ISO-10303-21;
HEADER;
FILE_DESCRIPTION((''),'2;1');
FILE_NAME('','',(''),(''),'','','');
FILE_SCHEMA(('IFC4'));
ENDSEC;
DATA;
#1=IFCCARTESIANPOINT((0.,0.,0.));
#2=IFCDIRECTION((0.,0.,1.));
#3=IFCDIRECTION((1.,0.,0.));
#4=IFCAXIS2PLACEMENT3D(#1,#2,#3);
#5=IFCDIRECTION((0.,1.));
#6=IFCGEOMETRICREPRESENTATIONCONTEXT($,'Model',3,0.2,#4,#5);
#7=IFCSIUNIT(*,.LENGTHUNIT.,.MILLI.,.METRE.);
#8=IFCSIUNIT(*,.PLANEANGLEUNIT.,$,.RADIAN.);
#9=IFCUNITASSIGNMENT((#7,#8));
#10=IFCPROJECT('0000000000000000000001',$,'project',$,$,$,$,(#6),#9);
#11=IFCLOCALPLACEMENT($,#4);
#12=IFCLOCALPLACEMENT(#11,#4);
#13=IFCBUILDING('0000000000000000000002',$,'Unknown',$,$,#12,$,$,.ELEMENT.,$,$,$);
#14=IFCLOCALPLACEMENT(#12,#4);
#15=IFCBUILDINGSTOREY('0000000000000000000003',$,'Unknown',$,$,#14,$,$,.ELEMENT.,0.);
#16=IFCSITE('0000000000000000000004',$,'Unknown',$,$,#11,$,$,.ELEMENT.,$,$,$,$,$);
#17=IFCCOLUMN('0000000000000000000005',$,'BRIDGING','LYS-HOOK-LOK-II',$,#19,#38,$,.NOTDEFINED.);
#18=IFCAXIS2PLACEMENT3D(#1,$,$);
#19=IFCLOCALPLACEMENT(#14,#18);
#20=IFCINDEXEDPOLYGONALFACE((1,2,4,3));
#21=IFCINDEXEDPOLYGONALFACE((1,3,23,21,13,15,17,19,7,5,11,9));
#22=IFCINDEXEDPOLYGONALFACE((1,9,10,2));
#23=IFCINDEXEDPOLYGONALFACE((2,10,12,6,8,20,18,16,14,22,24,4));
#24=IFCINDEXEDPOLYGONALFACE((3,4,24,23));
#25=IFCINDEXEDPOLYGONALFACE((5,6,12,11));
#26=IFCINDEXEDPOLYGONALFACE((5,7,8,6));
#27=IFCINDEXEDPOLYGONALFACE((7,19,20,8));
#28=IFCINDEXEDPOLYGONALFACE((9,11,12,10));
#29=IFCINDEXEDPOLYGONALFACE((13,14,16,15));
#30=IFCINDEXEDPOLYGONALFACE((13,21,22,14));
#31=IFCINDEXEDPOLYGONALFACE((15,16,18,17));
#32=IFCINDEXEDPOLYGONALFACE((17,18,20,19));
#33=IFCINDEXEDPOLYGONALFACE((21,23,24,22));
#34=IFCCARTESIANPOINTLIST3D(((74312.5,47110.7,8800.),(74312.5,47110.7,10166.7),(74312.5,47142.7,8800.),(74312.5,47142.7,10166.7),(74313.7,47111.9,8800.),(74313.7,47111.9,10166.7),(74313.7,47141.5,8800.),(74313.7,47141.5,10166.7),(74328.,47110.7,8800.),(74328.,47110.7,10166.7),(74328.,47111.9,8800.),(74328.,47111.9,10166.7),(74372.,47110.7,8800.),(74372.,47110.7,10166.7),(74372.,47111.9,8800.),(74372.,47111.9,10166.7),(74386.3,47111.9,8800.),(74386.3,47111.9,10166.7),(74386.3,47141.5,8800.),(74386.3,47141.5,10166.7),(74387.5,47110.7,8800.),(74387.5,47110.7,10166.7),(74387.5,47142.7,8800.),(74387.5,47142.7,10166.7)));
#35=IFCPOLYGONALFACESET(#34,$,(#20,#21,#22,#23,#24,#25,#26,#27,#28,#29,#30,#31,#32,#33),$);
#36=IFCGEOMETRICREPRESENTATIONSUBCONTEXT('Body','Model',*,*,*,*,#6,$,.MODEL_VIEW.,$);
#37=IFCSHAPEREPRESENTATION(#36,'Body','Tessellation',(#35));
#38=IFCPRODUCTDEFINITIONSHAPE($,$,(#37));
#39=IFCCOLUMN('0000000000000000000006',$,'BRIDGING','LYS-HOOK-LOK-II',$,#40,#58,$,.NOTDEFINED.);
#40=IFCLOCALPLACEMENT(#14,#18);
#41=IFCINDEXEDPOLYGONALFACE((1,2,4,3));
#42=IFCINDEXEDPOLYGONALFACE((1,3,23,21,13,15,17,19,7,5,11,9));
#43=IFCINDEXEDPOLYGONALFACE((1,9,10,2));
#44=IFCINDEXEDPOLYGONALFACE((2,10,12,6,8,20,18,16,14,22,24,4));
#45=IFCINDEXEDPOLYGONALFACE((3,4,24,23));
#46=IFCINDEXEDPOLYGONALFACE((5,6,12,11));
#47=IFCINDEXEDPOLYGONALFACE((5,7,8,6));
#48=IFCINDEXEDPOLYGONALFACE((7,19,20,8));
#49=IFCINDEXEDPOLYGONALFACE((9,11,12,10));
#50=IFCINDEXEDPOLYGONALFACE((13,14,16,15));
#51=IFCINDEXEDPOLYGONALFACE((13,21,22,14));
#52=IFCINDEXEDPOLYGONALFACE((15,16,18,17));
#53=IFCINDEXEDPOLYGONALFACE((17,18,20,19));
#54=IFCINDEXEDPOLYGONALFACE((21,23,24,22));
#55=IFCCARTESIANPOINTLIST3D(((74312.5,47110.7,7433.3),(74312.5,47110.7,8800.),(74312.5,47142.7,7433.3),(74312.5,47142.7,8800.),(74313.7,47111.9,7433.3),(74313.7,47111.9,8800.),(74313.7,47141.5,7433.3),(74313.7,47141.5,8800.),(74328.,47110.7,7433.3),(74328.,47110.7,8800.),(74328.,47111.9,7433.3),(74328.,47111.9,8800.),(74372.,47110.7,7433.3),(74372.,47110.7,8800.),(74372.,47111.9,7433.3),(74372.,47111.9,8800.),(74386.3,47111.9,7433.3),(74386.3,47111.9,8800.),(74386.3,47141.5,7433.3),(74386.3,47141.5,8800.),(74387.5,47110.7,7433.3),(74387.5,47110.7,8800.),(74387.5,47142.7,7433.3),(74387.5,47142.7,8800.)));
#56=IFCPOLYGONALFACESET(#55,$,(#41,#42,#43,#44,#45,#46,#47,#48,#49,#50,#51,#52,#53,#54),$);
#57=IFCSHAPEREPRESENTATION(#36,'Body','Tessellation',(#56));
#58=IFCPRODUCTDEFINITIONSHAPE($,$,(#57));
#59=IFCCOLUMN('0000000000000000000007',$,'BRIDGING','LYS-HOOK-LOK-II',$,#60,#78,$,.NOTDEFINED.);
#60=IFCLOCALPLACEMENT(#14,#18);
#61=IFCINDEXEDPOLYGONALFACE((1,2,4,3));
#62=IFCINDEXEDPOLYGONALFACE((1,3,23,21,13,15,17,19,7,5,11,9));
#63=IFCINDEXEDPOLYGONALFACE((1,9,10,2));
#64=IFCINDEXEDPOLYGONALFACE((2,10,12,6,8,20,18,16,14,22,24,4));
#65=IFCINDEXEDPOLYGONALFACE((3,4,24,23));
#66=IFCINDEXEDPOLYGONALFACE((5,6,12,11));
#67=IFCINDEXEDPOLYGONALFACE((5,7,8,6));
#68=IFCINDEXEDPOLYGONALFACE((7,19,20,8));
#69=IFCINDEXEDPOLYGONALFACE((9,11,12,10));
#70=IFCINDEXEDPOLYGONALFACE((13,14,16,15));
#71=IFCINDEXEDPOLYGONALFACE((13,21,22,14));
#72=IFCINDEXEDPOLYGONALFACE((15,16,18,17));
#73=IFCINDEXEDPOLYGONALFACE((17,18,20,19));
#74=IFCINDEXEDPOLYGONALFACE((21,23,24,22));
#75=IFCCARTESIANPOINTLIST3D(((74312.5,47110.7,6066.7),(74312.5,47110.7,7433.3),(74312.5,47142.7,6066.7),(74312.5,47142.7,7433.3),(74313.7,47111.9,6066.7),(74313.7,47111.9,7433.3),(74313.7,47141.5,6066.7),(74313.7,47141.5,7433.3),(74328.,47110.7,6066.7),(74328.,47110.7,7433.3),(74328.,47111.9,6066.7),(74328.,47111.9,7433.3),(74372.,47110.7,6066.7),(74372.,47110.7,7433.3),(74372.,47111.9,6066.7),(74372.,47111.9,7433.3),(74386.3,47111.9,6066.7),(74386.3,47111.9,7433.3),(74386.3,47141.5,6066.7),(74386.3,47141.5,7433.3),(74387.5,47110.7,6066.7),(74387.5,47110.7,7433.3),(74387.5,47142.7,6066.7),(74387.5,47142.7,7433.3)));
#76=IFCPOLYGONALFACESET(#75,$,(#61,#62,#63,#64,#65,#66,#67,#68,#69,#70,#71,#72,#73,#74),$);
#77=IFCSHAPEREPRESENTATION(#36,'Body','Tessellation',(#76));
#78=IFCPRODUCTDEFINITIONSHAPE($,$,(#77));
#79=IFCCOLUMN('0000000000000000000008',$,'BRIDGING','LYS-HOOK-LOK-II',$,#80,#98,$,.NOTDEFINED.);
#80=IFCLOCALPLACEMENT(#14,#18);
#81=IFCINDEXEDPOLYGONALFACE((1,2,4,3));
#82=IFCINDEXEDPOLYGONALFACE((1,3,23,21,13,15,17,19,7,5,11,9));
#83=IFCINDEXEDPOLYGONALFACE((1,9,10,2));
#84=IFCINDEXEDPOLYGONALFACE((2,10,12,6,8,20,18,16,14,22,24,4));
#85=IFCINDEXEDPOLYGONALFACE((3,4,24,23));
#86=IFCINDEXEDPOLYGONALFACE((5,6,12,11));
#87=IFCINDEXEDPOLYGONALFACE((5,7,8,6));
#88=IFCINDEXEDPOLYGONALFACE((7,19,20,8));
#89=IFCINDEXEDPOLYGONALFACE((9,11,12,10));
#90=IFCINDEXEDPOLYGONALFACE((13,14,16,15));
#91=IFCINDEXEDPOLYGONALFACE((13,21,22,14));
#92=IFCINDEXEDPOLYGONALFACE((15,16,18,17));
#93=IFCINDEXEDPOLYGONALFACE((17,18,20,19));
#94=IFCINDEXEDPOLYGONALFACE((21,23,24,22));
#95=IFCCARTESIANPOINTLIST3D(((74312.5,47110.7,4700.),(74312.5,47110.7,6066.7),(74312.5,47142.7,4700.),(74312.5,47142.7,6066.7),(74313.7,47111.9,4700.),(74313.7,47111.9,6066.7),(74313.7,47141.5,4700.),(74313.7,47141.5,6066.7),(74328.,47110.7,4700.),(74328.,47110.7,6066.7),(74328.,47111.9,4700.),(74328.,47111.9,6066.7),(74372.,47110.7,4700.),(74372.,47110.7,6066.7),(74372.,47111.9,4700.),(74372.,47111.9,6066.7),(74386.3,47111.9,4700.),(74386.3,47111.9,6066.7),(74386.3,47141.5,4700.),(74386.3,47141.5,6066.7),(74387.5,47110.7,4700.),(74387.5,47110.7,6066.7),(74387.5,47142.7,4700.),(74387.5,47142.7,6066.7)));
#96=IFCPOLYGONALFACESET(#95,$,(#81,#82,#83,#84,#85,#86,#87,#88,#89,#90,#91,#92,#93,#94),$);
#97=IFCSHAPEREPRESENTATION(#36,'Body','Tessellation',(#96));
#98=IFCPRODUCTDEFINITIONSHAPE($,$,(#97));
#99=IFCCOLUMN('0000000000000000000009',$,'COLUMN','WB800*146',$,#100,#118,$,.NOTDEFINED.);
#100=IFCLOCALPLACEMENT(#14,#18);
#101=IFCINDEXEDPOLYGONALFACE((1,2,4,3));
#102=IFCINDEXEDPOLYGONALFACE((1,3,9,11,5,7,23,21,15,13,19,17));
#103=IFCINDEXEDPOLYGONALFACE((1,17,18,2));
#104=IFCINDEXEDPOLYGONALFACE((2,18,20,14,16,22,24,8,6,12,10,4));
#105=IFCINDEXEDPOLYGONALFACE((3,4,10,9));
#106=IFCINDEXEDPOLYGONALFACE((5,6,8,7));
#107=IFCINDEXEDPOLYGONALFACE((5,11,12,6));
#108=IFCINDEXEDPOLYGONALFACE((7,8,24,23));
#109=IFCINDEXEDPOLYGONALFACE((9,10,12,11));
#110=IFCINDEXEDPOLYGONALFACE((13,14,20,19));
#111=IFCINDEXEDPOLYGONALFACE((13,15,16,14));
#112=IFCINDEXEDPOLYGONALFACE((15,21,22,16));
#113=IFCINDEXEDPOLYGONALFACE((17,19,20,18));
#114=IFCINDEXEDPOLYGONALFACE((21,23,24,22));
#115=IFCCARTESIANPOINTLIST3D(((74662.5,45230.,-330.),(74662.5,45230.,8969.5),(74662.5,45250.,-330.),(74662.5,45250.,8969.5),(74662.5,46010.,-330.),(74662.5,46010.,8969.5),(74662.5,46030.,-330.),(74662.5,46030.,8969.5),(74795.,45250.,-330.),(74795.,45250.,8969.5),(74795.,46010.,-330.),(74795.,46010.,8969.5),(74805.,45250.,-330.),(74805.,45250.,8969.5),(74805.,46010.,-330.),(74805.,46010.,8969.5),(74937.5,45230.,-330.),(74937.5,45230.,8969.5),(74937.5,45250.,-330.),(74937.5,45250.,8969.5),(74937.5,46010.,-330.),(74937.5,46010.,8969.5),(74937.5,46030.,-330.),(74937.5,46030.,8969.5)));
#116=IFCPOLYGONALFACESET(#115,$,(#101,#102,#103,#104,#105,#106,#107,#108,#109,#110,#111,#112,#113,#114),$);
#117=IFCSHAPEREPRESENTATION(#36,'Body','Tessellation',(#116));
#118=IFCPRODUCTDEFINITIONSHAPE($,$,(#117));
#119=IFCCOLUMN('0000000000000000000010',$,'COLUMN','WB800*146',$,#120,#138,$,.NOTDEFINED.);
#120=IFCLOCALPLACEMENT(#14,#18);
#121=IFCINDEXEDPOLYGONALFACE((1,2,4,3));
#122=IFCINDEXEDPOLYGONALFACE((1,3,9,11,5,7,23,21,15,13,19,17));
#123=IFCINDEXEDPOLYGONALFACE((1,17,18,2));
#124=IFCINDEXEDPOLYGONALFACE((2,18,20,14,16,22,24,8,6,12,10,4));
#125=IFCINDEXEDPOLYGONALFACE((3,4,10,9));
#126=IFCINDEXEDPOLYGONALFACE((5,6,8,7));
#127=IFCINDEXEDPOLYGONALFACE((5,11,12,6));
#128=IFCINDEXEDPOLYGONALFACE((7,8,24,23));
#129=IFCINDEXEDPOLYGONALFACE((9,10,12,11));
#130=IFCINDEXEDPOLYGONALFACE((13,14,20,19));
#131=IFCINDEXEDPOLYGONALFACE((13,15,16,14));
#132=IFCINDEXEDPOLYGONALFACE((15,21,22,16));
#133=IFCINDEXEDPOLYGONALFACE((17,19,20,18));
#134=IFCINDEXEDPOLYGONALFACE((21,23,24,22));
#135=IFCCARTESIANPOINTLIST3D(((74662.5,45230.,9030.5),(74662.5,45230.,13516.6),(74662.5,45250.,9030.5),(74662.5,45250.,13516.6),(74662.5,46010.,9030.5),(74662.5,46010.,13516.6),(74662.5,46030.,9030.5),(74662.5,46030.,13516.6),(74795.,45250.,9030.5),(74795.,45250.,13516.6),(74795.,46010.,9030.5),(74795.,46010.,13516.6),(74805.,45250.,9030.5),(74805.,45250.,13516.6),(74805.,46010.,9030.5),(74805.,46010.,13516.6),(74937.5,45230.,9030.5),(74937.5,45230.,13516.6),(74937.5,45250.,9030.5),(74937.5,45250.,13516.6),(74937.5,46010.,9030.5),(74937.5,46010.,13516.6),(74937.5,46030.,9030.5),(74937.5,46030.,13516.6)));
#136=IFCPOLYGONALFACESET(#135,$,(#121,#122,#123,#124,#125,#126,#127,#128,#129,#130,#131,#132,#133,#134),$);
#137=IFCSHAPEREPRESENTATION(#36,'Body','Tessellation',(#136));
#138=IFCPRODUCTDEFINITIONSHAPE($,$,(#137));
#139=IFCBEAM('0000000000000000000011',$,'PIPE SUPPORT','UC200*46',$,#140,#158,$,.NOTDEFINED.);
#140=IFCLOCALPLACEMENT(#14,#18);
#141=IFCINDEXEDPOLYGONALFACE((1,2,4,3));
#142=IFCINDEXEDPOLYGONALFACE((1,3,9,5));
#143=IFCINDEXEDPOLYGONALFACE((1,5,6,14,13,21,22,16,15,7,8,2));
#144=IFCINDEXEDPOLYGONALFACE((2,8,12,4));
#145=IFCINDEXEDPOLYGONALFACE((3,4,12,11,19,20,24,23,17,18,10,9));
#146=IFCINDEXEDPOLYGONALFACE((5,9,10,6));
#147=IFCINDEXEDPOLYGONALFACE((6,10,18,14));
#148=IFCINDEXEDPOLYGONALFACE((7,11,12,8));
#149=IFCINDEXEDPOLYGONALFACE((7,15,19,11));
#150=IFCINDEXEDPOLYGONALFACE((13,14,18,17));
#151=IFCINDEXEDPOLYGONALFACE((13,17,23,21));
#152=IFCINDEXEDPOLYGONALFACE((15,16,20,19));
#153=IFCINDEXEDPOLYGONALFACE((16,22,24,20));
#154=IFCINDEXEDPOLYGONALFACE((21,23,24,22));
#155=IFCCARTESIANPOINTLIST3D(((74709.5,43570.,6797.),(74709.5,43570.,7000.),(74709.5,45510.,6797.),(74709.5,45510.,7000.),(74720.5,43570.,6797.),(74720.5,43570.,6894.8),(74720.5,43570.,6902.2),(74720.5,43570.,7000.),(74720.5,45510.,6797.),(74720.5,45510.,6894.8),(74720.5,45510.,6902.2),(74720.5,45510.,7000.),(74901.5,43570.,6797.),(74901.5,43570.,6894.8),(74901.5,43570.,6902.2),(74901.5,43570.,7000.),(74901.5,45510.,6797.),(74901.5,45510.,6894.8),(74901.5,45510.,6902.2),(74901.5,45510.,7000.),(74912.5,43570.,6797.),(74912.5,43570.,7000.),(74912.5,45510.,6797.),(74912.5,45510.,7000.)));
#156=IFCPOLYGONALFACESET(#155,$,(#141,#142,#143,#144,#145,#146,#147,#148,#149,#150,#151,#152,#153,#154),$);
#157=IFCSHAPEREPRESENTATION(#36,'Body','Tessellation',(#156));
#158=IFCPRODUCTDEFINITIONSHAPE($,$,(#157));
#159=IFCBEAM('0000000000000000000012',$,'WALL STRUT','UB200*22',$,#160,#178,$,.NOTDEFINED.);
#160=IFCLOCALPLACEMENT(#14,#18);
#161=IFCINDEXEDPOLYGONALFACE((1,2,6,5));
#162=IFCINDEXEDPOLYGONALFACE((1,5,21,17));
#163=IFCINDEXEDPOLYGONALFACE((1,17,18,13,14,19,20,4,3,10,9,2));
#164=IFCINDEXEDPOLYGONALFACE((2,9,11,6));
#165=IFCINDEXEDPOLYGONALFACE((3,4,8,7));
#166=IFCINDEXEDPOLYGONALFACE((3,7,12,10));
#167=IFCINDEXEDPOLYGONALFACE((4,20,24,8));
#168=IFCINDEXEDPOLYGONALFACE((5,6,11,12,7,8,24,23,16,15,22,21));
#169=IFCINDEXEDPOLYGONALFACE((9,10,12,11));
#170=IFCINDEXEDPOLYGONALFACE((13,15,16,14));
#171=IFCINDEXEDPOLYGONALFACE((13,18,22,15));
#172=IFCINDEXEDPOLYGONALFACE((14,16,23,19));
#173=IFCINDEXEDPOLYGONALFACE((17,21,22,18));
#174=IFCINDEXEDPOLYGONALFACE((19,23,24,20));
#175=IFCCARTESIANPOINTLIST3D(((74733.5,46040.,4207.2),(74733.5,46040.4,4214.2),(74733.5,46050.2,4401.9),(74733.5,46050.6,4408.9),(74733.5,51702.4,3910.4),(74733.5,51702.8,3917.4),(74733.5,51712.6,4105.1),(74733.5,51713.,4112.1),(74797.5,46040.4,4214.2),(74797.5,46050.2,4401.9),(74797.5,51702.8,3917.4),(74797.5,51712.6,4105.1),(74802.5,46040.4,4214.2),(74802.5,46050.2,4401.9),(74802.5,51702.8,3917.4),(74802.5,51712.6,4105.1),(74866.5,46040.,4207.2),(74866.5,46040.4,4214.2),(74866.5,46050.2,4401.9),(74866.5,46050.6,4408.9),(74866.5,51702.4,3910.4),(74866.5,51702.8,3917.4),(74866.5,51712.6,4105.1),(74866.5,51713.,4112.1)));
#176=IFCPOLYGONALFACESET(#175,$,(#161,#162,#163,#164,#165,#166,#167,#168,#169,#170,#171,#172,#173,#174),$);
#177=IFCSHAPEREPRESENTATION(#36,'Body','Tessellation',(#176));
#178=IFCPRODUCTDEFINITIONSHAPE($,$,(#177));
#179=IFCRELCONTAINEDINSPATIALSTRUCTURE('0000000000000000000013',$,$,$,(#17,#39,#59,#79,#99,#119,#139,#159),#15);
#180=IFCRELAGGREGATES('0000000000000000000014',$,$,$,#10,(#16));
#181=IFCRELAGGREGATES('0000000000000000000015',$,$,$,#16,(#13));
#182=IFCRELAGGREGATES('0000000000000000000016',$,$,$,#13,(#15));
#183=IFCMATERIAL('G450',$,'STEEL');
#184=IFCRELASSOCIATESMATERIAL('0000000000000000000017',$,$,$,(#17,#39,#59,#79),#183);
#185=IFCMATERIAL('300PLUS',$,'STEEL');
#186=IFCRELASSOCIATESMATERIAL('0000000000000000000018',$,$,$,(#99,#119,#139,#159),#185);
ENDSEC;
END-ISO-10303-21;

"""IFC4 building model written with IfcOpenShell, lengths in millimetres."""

from ifc_helpers import new_model, si_unit, direction, frame, origin_with_axes, place, context, subcontext, project, spatial, line, indexed_curve, outline, extrude, material, element, save


model = new_model("IFC4")

# Units and contexts
model_context = context("Model", 3, precision=0.2, world=origin_with_axes(), true_north=direction((0.0, 1.0)))
body_context = subcontext(model_context, "Body", "Model", "MODEL_VIEW")
ifc_project = project(units=[si_unit("LENGTHUNIT", "METRE", prefix="MILLI"), si_unit("PLANEANGLEUNIT", "RADIAN")], contexts=[model_context])

# Site, building, storey
site_placement = place(None, origin_with_axes())
site = spatial("IfcSite", under=ifc_project, at=site_placement, Name="Unknown", CompositionType="ELEMENT")
building_placement = place(site_placement, origin_with_axes())
building = spatial("IfcBuilding", under=site, at=building_placement, Name="Unknown", CompositionType="ELEMENT")
storey_placement = place(building_placement, origin_with_axes())
storey = spatial("IfcBuildingStorey", under=building, at=storey_placement, Name="Unknown", CompositionType="ELEMENT", Elevation=0.0)

# Columns
ifc_material_1 = material(Name="G450", Category="STEEL")
for number, where, z_axis, x_axis, name in (
    (1, (74350.0, 47126.7, 8800.0), (0.0, -1.0, 0.0), (0.0, 0.0, 1.0), "BRIDGING"),
    (2, (74350.0, 47126.7, 7433.3), (0.0, -1.0, 0.0), (0.0, 0.0, 1.0), "BRIDGING"),
):
    element("IfcColumn", number, at=place(storey_placement, frame(where, z_axis=z_axis, x_axis=x_axis)), inside=storey, material=ifc_material_1, Name=name, Description="LYS-HOOK-LOK-II", PredefinedType="NOTDEFINED", context=body_context, shape_type="SolidModel", body=[
        extrude(outline(indexed_curve([(16.0, -37.5), (16.0, -22.0), (14.8, -22.0), (14.8, -36.3), (-14.8, -36.3), (-14.8, 36.3), (14.8, 36.3), (14.8, 22.0), (16.0, 22.0), (16.0, 37.5), (-16.0, 37.5), (-16.0, -37.5)], segments=[line(1, 2, 3, 4, 5, 6, 7, 8, 9, 10, 11, 12, 1)])), frame((0.0, 0.0, 0.0), z_axis=(-1.0, 0.0, 0.0), x_axis=(0.0, 0.0, 1.0)), (0.0, 0.0, -1.0), 1366.7),
    ])
column_1_placement = place(storey_placement, frame((74350.0, 47126.7, 6066.7), z_axis=(0.0, -1.0, 0.0), x_axis=(0.0, 0.0, 1.0)))
element("IfcColumn", 3, at=column_1_placement, inside=storey, material=ifc_material_1, Name="BRIDGING", Description="LYS-HOOK-LOK-II", PredefinedType="NOTDEFINED", context=body_context, shape_type="SolidModel", body=[
    extrude(outline(indexed_curve([(16.0, -37.5), (16.0, -22.0), (14.8, -22.0), (14.8, -36.3), (-14.8, -36.3), (-14.8, 36.3), (14.8, 36.3), (14.8, 22.0), (16.0, 22.0), (16.0, 37.5), (-16.0, 37.5), (-16.0, -37.5)], segments=[line(1, 2, 3, 4, 5, 6, 7, 8, 9, 10, 11, 12, 1)])), frame((0.0, 0.0, 0.0), z_axis=(-1.0, 0.0, 0.0), x_axis=(0.0, 0.0, 1.0)), (0.0, 0.0, -1.0), 1366.6),
])
column_2_placement = place(storey_placement, frame((74350.0, 47126.7, 4700.0), z_axis=(0.0, -1.0, 0.0), x_axis=(0.0, 0.0, 1.0)))
element("IfcColumn", 4, at=column_2_placement, inside=storey, material=ifc_material_1, Name="BRIDGING", Description="LYS-HOOK-LOK-II", PredefinedType="NOTDEFINED", context=body_context, shape_type="SolidModel", body=[
    extrude(outline(indexed_curve([(16.0, -37.5), (16.0, -22.0), (14.8, -22.0), (14.8, -36.3), (-14.8, -36.3), (-14.8, 36.3), (14.8, 36.3), (14.8, 22.0), (16.0, 22.0), (16.0, 37.5), (-16.0, 37.5), (-16.0, -37.5)], segments=[line(1, 2, 3, 4, 5, 6, 7, 8, 9, 10, 11, 12, 1)])), frame((0.0, 0.0, 0.0), z_axis=(-1.0, 0.0, 0.0), x_axis=(0.0, 0.0, 1.0)), (0.0, 0.0, -1.0), 1366.7),
])
ifc_material_2 = material(Name="300PLUS", Category="STEEL")
column_3_placement = place(storey_placement, frame((74800.0, 45630.0, -330.0), z_axis=(-1.0, 0.0, 0.0), x_axis=(0.0, 0.0, 1.0)))
element("IfcColumn", 5, at=column_3_placement, inside=storey, material=ifc_material_2, Name="COLUMN", Description="WB800*146", PredefinedType="NOTDEFINED", context=body_context, shape_type="SolidModel", body=[
    extrude(outline(indexed_curve([(-137.5, -400.0), (137.5, -400.0), (137.5, -380.0), (5.0, -380.0), (5.0, 380.0), (137.5, 380.0), (137.5, 400.0), (-137.5, 400.0), (-137.5, 380.0), (-5.0, 380.0), (-5.0, -380.0), (-137.5, -380.0)], segments=[line(1, 2, 3, 4, 5, 6, 7, 8, 9, 10, 11, 12, 1)])), frame((0.0, 0.0, 0.0), z_axis=(-1.0, 0.0, 0.0), x_axis=(0.0, 0.0, 1.0)), (0.0, 0.0, -1.0), 9299.5),
])
column_4_placement = place(storey_placement, frame((74800.0, 45630.0, 9030.5), z_axis=(-1.0, 0.0, 0.0), x_axis=(0.0, 0.0, 1.0)))
element("IfcColumn", 6, at=column_4_placement, inside=storey, material=ifc_material_2, Name="COLUMN", Description="WB800*146", PredefinedType="NOTDEFINED", context=body_context, shape_type="SolidModel", body=[
    extrude(outline(indexed_curve([(-137.5, -400.0), (137.5, -400.0), (137.5, -380.0), (5.0, -380.0), (5.0, 380.0), (137.5, 380.0), (137.5, 400.0), (-137.5, 400.0), (-137.5, 380.0), (-5.0, 380.0), (-5.0, -380.0), (-137.5, -380.0)], segments=[line(1, 2, 3, 4, 5, 6, 7, 8, 9, 10, 11, 12, 1)])), frame((0.0, 0.0, 0.0), z_axis=(-1.0, 0.0, 0.0), x_axis=(0.0, 0.0, 1.0)), (0.0, 0.0, -1.0), 4486.1),
])

# Beams
beam_1_placement = place(storey_placement, frame((74811.0, 45510.0, 6898.5), z_axis=(0.0, 0.0, 1.0), x_axis=(0.0, -1.0, 0.0)))
element("IfcBeam", 7, at=beam_1_placement, inside=storey, material=ifc_material_2, Name="PIPE SUPPORT", Description="UC200*46", PredefinedType="NOTDEFINED", context=body_context, shape_type="SolidModel", body=[
    extrude(outline(indexed_curve([(-101.5, -101.5), (101.5, -101.5), (101.5, -90.5), (3.6, -90.5), (3.6, 90.5), (101.5, 90.5), (101.5, 101.5), (-101.5, 101.5), (-101.5, 90.5), (-3.6, 90.5), (-3.6, -90.5), (-101.5, -90.5)], segments=[line(1, 2, 3, 4, 5, 6, 7, 8, 9, 10, 11, 12, 1)])), frame((0.0, 0.0, 0.0), z_axis=(-1.0, 0.0, 0.0), x_axis=(0.0, 0.0, 1.0)), (0.0, 0.0, -1.0), 1940.0),
])
beam_2_placement = place(storey_placement, frame((74800.0, 46045.3, 4308.0), z_axis=(1.0, 0.0, 0.0), x_axis=(0.0, 0.998629, -0.052344)))
element("IfcBeam", 8, at=beam_2_placement, inside=storey, material=ifc_material_2, Name="WALL STRUT", Description="UB200*22", PredefinedType="NOTDEFINED", context=body_context, shape_type="SolidModel", body=[
    extrude(outline(indexed_curve([(-66.5, -101.0), (66.5, -101.0), (66.5, -94.0), (2.5, -94.0), (2.5, 94.0), (66.5, 94.0), (66.5, 101.0), (-66.5, 101.0), (-66.5, 94.0), (-2.5, 94.0), (-2.5, -94.0), (-66.5, -94.0)], segments=[line(1, 2, 3, 4, 5, 6, 7, 8, 9, 10, 11, 12, 1)])), frame((0.0, 0.0, 0.0), z_axis=(-1.0, 0.0, 0.0), x_axis=(0.0, 0.0, 1.0)), (0.0, 0.0, -1.0), 5670.2),
])

save(model, "model.ifc")
